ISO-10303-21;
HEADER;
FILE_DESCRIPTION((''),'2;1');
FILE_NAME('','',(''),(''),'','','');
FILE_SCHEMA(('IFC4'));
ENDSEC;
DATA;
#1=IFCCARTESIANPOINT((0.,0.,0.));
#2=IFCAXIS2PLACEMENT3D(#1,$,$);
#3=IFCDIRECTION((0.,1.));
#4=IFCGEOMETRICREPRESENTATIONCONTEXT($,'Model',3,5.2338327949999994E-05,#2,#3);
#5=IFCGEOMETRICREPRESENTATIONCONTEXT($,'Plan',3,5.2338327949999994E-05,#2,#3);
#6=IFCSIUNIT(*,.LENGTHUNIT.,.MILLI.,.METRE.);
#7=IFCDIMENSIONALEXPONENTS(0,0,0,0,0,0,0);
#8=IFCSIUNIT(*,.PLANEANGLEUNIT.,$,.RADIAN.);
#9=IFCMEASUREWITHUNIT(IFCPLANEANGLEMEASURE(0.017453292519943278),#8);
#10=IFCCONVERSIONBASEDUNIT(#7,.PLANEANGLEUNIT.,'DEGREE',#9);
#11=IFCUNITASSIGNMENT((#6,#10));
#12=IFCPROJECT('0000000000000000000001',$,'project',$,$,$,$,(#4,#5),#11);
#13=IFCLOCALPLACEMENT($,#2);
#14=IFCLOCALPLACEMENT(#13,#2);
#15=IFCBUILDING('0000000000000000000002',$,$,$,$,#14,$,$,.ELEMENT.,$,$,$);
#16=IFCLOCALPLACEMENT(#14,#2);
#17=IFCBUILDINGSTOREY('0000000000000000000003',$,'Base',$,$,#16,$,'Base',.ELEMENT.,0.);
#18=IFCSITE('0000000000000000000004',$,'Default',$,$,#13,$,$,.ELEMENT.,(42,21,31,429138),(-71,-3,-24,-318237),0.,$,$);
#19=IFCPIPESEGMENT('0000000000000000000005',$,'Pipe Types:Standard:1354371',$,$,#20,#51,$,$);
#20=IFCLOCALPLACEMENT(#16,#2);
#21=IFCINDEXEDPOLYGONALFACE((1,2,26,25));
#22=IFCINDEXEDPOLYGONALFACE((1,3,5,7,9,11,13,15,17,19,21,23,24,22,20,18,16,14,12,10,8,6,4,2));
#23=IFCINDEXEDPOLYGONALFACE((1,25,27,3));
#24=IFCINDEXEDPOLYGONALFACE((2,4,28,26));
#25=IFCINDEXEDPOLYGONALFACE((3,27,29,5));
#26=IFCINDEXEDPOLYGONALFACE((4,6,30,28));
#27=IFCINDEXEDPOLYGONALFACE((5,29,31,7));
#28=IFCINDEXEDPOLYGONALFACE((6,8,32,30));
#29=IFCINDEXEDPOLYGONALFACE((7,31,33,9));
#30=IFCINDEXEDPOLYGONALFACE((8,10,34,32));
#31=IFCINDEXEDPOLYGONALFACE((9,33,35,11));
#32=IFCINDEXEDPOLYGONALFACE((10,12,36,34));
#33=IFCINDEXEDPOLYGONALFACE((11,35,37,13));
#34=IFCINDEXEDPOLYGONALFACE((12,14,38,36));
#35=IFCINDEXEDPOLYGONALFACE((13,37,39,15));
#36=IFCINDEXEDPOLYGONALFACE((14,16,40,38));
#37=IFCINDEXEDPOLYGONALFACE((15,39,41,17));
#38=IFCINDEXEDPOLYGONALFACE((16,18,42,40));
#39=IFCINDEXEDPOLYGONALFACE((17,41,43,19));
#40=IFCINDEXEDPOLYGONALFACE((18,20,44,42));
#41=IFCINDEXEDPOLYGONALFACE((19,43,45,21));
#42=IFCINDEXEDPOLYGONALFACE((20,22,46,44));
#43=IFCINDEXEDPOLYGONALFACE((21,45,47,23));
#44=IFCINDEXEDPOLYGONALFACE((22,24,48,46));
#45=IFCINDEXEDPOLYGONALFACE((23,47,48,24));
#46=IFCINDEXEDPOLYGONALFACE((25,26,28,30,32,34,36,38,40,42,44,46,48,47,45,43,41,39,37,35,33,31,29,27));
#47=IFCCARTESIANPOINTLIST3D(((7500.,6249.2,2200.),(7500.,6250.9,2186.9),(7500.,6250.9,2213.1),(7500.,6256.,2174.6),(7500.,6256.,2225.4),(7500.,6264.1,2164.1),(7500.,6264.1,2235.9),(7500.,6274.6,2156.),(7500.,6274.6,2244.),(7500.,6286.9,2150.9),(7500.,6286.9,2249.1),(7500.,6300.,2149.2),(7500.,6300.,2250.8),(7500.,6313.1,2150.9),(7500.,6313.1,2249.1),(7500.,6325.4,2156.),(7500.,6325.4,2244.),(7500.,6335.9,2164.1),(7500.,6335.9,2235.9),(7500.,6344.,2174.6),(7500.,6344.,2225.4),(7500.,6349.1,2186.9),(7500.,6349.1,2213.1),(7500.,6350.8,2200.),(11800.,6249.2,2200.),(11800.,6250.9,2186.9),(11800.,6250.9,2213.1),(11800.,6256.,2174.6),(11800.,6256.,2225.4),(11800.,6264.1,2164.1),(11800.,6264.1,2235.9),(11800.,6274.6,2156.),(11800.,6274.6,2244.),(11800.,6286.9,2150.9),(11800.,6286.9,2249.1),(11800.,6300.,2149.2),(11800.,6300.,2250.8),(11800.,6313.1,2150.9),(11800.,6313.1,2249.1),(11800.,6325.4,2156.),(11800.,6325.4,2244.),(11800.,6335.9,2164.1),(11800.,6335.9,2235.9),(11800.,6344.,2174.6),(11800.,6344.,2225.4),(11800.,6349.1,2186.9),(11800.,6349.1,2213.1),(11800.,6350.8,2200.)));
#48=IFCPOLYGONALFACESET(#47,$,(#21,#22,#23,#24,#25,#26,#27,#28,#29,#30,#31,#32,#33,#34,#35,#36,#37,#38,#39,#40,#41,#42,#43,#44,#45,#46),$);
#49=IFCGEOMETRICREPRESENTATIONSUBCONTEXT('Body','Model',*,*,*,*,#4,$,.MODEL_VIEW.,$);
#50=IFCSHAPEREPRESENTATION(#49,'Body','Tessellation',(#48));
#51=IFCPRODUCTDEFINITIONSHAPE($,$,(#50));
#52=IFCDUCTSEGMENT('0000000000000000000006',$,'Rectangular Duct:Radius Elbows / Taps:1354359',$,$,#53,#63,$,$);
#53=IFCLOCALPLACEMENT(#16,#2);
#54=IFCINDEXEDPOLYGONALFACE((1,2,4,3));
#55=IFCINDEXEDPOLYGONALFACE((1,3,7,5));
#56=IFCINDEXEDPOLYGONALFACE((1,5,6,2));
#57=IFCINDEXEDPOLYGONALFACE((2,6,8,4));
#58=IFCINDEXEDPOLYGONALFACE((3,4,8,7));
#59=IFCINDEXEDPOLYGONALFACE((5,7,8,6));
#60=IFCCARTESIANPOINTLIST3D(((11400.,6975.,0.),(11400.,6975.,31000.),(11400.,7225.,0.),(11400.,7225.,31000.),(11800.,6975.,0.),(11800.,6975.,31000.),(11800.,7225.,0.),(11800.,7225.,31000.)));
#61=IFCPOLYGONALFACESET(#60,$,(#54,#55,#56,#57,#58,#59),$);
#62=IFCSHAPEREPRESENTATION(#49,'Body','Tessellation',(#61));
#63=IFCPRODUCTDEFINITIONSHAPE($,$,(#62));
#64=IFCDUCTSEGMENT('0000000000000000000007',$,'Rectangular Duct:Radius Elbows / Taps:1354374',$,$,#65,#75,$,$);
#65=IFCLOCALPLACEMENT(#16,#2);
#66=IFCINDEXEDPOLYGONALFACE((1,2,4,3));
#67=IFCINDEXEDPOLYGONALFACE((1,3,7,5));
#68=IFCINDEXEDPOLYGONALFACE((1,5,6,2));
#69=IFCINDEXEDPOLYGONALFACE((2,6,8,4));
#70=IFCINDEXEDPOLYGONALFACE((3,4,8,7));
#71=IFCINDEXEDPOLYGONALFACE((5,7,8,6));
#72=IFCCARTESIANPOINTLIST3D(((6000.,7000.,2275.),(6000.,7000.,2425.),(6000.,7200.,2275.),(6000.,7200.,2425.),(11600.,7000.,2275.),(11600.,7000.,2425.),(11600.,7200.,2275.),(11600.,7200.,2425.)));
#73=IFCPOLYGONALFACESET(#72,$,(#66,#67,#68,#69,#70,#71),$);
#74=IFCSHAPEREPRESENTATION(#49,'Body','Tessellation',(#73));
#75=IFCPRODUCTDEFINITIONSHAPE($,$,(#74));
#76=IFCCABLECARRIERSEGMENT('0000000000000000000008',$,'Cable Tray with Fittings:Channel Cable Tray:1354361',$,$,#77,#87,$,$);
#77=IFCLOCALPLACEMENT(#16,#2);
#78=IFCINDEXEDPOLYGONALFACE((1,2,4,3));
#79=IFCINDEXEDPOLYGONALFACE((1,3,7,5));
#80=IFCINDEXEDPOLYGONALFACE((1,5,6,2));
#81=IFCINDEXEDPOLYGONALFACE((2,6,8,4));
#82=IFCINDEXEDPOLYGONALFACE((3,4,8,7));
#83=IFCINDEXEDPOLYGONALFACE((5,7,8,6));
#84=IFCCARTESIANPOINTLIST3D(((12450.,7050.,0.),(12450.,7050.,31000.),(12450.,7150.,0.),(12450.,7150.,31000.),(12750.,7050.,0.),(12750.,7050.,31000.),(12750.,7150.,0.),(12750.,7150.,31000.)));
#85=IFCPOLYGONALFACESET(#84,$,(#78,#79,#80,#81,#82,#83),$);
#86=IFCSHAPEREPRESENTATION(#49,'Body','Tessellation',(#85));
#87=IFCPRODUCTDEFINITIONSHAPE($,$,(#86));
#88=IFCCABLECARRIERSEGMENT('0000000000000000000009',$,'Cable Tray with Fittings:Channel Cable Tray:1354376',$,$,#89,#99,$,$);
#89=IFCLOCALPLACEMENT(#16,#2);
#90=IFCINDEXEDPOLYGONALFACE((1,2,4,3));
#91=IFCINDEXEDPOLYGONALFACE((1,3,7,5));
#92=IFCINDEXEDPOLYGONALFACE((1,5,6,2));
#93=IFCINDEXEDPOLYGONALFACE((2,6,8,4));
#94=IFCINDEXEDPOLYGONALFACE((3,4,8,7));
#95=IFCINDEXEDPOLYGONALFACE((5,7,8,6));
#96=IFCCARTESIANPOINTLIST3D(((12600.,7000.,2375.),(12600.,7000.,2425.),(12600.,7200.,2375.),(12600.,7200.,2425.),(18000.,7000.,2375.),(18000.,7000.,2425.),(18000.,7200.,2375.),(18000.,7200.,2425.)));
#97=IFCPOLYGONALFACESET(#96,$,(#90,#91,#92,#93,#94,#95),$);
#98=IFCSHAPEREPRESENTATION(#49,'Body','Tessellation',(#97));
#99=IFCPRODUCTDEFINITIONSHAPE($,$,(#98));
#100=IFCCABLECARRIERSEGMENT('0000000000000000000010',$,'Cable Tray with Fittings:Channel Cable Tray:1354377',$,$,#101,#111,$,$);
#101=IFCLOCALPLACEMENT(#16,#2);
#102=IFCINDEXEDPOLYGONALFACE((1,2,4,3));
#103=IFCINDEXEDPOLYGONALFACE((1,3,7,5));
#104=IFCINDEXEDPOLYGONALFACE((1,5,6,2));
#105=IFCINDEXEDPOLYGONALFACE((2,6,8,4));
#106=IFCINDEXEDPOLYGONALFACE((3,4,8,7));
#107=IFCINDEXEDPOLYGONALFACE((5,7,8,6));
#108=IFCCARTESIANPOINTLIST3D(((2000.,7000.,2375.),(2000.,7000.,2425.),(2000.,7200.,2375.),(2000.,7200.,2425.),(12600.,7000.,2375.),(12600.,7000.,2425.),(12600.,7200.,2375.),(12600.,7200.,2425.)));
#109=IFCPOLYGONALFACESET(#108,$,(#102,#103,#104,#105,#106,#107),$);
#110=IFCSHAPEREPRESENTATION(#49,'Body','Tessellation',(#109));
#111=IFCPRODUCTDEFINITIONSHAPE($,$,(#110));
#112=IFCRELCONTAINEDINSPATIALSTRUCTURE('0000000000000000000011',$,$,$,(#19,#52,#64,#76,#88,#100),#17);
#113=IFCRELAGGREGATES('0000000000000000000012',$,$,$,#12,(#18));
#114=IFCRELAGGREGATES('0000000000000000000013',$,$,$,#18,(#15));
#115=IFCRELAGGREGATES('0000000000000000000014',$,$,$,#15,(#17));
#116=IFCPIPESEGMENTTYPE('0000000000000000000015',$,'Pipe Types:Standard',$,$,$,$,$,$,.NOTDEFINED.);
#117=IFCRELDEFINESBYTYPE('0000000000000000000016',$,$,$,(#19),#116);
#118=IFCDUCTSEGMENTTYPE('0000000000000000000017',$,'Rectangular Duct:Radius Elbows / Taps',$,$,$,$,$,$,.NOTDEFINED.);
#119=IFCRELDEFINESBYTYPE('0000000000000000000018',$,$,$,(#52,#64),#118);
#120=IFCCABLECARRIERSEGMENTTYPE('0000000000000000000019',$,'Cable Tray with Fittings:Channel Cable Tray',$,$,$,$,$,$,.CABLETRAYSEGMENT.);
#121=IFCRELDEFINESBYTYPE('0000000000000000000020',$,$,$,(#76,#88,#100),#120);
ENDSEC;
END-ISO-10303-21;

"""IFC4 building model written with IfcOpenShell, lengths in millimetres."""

from ifc_helpers import new_model, entity, si_unit, converted_unit, direction, frame, origin, place, context, subcontext, project, spatial, arc, indexed_curve, outline, extrude, type_object, element, save


model = new_model("IFC4")

# Units and contexts
model_context = context("Model", 3, precision=5.2338327949999994e-05, world=origin(), true_north=direction((0.0, 1.0)))
plan_context = context("Plan", 3, precision=5.2338327949999994e-05, world=origin(), true_north=direction((0.0, 1.0)))
body_context = subcontext(model_context, "Body", "Model", "MODEL_VIEW")
ifc_project = project(units=[si_unit("LENGTHUNIT", "METRE", prefix="MILLI"), converted_unit("PLANEANGLEUNIT", "DEGREE", entity("IfcPlaneAngleMeasure", 0.017453292519943278), si_unit("PLANEANGLEUNIT", "RADIAN"), dimensions=[0, 0, 0, 0, 0, 0, 0])], contexts=[model_context, plan_context])

# Site, building, storey
site_placement = place(None, origin())
site = spatial("IfcSite", under=ifc_project, at=site_placement, Name="Default", CompositionType="ELEMENT", RefLatitude=(42, 21, 31, 429138), RefLongitude=(-71, -3, -24, -318237), RefElevation=0.0)
building_placement = place(site_placement, origin())
building = spatial("IfcBuilding", under=site, at=building_placement, CompositionType="ELEMENT")
storey_placement = place(building_placement, origin())
storey = spatial("IfcBuildingStorey", under=building, at=storey_placement, Name="Base", LongName="Base", CompositionType="ELEMENT", Elevation=0.0)

# Pipe segment
pipe_segment_type = type_object("IfcPipeSegmentType", Name="Pipe Types:Standard", PredefinedType="NOTDEFINED")
pipe_segment_1_placement = place(storey_placement, origin())
element("IfcPipeSegment", 1, at=pipe_segment_1_placement, inside=storey, type_object=pipe_segment_type, Name="Pipe Types:Standard:1354371", context=body_context, shape_type="SweptSolid", body=[
    extrude(outline(indexed_curve([(50.8, 0.0), (35.9, 35.9), (0.0, 50.8), (-35.9, 35.9), (-50.8, 0.0), (-35.9, -35.9), (0.0, -50.8), (35.9, -35.9)], segments=[arc(1, 2, 3), arc(3, 4, 5), arc(5, 6, 7), arc(7, 8, 1)], self_intersect=False)), frame((7500.0, 6300.0, 2200.0), z_axis=(1.0, 0.0, 0.0), x_axis=(0.0, 1.0, 0.0)), (0.0, 0.0, 1.0), 4300.0),
])

# Duct segments
duct_segment_type = type_object("IfcDuctSegmentType", Name="Rectangular Duct:Radius Elbows / Taps", PredefinedType="NOTDEFINED")
duct_segment_1_placement = place(storey_placement, origin())
element("IfcDuctSegment", 2, at=duct_segment_1_placement, inside=storey, type_object=duct_segment_type, Name="Rectangular Duct:Radius Elbows / Taps:1354359", context=body_context, shape_type="SweptSolid", body=[
    extrude(outline(indexed_curve([(-125.0, -200.0), (125.0, -200.0), (125.0, 200.0), (-125.0, 200.0), (-125.0, -200.0)], self_intersect=False)), frame((11600.0, 7100.0, 0.0), z_axis=(0.0, 0.0, 1.0), x_axis=(0.0, 1.0, 0.0)), (0.0, 0.0, 1.0), 31000.0),
])
duct_segment_2_placement = place(storey_placement, origin())
element("IfcDuctSegment", 3, at=duct_segment_2_placement, inside=storey, type_object=duct_segment_type, Name="Rectangular Duct:Radius Elbows / Taps:1354374", context=body_context, shape_type="SweptSolid", body=[
    extrude(outline(indexed_curve([(-2800.0, -100.0), (2800.0, -100.0), (2800.0, 100.0), (-2800.0, 100.0), (-2800.0, -100.0)], self_intersect=False)), frame((8800.0, 7100.0, 2275.0), z_axis=(0.0, 0.0, 1.0), x_axis=(-1.0, 0.0, 0.0)), (0.0, 0.0, 1.0), 150.0),
])

# Cable carrier segments
cable_carrier_segment_type = type_object("IfcCableCarrierSegmentType", Name="Cable Tray with Fittings:Channel Cable Tray", PredefinedType="CABLETRAYSEGMENT")
cable_carrier_segment_1_placement = place(storey_placement, origin())
element("IfcCableCarrierSegment", 4, at=cable_carrier_segment_1_placement, inside=storey, type_object=cable_carrier_segment_type, Name="Cable Tray with Fittings:Channel Cable Tray:1354361", context=body_context, shape_type="SweptSolid", body=[
    extrude(outline(indexed_curve([(-150.0, -50.0), (150.0, -50.0), (150.0, 50.0), (-150.0, 50.0), (-150.0, -50.0)], self_intersect=False)), frame((12600.0, 7100.0, 0.0)), (0.0, 0.0, 1.0), 31000.0),
])
cable_carrier_segment_2_placement = place(storey_placement, origin())
element("IfcCableCarrierSegment", 5, at=cable_carrier_segment_2_placement, inside=storey, type_object=cable_carrier_segment_type, Name="Cable Tray with Fittings:Channel Cable Tray:1354376", context=body_context, shape_type="SweptSolid", body=[
    extrude(outline(indexed_curve([(-2700.0, -100.0), (2700.0, -100.0), (2700.0, 100.0), (-2700.0, 100.0), (-2700.0, -100.0)], self_intersect=False)), frame((15300.0, 7100.0, 2375.0)), (0.0, 0.0, 1.0), 50.0),
])
cable_carrier_segment_3_placement = place(storey_placement, origin())
element("IfcCableCarrierSegment", 6, at=cable_carrier_segment_3_placement, inside=storey, type_object=cable_carrier_segment_type, Name="Cable Tray with Fittings:Channel Cable Tray:1354377", context=body_context, shape_type="SweptSolid", body=[
    extrude(outline(indexed_curve([(-5300.0, -100.0), (5300.0, -100.0), (5300.0, 100.0), (-5300.0, 100.0), (-5300.0, -100.0)], self_intersect=False)), frame((7300.0, 7100.0, 2375.0), z_axis=(0.0, 0.0, 1.0), x_axis=(-1.0, 0.0, 0.0)), (0.0, 0.0, 1.0), 50.0),
])

save(model, "model.ifc")
